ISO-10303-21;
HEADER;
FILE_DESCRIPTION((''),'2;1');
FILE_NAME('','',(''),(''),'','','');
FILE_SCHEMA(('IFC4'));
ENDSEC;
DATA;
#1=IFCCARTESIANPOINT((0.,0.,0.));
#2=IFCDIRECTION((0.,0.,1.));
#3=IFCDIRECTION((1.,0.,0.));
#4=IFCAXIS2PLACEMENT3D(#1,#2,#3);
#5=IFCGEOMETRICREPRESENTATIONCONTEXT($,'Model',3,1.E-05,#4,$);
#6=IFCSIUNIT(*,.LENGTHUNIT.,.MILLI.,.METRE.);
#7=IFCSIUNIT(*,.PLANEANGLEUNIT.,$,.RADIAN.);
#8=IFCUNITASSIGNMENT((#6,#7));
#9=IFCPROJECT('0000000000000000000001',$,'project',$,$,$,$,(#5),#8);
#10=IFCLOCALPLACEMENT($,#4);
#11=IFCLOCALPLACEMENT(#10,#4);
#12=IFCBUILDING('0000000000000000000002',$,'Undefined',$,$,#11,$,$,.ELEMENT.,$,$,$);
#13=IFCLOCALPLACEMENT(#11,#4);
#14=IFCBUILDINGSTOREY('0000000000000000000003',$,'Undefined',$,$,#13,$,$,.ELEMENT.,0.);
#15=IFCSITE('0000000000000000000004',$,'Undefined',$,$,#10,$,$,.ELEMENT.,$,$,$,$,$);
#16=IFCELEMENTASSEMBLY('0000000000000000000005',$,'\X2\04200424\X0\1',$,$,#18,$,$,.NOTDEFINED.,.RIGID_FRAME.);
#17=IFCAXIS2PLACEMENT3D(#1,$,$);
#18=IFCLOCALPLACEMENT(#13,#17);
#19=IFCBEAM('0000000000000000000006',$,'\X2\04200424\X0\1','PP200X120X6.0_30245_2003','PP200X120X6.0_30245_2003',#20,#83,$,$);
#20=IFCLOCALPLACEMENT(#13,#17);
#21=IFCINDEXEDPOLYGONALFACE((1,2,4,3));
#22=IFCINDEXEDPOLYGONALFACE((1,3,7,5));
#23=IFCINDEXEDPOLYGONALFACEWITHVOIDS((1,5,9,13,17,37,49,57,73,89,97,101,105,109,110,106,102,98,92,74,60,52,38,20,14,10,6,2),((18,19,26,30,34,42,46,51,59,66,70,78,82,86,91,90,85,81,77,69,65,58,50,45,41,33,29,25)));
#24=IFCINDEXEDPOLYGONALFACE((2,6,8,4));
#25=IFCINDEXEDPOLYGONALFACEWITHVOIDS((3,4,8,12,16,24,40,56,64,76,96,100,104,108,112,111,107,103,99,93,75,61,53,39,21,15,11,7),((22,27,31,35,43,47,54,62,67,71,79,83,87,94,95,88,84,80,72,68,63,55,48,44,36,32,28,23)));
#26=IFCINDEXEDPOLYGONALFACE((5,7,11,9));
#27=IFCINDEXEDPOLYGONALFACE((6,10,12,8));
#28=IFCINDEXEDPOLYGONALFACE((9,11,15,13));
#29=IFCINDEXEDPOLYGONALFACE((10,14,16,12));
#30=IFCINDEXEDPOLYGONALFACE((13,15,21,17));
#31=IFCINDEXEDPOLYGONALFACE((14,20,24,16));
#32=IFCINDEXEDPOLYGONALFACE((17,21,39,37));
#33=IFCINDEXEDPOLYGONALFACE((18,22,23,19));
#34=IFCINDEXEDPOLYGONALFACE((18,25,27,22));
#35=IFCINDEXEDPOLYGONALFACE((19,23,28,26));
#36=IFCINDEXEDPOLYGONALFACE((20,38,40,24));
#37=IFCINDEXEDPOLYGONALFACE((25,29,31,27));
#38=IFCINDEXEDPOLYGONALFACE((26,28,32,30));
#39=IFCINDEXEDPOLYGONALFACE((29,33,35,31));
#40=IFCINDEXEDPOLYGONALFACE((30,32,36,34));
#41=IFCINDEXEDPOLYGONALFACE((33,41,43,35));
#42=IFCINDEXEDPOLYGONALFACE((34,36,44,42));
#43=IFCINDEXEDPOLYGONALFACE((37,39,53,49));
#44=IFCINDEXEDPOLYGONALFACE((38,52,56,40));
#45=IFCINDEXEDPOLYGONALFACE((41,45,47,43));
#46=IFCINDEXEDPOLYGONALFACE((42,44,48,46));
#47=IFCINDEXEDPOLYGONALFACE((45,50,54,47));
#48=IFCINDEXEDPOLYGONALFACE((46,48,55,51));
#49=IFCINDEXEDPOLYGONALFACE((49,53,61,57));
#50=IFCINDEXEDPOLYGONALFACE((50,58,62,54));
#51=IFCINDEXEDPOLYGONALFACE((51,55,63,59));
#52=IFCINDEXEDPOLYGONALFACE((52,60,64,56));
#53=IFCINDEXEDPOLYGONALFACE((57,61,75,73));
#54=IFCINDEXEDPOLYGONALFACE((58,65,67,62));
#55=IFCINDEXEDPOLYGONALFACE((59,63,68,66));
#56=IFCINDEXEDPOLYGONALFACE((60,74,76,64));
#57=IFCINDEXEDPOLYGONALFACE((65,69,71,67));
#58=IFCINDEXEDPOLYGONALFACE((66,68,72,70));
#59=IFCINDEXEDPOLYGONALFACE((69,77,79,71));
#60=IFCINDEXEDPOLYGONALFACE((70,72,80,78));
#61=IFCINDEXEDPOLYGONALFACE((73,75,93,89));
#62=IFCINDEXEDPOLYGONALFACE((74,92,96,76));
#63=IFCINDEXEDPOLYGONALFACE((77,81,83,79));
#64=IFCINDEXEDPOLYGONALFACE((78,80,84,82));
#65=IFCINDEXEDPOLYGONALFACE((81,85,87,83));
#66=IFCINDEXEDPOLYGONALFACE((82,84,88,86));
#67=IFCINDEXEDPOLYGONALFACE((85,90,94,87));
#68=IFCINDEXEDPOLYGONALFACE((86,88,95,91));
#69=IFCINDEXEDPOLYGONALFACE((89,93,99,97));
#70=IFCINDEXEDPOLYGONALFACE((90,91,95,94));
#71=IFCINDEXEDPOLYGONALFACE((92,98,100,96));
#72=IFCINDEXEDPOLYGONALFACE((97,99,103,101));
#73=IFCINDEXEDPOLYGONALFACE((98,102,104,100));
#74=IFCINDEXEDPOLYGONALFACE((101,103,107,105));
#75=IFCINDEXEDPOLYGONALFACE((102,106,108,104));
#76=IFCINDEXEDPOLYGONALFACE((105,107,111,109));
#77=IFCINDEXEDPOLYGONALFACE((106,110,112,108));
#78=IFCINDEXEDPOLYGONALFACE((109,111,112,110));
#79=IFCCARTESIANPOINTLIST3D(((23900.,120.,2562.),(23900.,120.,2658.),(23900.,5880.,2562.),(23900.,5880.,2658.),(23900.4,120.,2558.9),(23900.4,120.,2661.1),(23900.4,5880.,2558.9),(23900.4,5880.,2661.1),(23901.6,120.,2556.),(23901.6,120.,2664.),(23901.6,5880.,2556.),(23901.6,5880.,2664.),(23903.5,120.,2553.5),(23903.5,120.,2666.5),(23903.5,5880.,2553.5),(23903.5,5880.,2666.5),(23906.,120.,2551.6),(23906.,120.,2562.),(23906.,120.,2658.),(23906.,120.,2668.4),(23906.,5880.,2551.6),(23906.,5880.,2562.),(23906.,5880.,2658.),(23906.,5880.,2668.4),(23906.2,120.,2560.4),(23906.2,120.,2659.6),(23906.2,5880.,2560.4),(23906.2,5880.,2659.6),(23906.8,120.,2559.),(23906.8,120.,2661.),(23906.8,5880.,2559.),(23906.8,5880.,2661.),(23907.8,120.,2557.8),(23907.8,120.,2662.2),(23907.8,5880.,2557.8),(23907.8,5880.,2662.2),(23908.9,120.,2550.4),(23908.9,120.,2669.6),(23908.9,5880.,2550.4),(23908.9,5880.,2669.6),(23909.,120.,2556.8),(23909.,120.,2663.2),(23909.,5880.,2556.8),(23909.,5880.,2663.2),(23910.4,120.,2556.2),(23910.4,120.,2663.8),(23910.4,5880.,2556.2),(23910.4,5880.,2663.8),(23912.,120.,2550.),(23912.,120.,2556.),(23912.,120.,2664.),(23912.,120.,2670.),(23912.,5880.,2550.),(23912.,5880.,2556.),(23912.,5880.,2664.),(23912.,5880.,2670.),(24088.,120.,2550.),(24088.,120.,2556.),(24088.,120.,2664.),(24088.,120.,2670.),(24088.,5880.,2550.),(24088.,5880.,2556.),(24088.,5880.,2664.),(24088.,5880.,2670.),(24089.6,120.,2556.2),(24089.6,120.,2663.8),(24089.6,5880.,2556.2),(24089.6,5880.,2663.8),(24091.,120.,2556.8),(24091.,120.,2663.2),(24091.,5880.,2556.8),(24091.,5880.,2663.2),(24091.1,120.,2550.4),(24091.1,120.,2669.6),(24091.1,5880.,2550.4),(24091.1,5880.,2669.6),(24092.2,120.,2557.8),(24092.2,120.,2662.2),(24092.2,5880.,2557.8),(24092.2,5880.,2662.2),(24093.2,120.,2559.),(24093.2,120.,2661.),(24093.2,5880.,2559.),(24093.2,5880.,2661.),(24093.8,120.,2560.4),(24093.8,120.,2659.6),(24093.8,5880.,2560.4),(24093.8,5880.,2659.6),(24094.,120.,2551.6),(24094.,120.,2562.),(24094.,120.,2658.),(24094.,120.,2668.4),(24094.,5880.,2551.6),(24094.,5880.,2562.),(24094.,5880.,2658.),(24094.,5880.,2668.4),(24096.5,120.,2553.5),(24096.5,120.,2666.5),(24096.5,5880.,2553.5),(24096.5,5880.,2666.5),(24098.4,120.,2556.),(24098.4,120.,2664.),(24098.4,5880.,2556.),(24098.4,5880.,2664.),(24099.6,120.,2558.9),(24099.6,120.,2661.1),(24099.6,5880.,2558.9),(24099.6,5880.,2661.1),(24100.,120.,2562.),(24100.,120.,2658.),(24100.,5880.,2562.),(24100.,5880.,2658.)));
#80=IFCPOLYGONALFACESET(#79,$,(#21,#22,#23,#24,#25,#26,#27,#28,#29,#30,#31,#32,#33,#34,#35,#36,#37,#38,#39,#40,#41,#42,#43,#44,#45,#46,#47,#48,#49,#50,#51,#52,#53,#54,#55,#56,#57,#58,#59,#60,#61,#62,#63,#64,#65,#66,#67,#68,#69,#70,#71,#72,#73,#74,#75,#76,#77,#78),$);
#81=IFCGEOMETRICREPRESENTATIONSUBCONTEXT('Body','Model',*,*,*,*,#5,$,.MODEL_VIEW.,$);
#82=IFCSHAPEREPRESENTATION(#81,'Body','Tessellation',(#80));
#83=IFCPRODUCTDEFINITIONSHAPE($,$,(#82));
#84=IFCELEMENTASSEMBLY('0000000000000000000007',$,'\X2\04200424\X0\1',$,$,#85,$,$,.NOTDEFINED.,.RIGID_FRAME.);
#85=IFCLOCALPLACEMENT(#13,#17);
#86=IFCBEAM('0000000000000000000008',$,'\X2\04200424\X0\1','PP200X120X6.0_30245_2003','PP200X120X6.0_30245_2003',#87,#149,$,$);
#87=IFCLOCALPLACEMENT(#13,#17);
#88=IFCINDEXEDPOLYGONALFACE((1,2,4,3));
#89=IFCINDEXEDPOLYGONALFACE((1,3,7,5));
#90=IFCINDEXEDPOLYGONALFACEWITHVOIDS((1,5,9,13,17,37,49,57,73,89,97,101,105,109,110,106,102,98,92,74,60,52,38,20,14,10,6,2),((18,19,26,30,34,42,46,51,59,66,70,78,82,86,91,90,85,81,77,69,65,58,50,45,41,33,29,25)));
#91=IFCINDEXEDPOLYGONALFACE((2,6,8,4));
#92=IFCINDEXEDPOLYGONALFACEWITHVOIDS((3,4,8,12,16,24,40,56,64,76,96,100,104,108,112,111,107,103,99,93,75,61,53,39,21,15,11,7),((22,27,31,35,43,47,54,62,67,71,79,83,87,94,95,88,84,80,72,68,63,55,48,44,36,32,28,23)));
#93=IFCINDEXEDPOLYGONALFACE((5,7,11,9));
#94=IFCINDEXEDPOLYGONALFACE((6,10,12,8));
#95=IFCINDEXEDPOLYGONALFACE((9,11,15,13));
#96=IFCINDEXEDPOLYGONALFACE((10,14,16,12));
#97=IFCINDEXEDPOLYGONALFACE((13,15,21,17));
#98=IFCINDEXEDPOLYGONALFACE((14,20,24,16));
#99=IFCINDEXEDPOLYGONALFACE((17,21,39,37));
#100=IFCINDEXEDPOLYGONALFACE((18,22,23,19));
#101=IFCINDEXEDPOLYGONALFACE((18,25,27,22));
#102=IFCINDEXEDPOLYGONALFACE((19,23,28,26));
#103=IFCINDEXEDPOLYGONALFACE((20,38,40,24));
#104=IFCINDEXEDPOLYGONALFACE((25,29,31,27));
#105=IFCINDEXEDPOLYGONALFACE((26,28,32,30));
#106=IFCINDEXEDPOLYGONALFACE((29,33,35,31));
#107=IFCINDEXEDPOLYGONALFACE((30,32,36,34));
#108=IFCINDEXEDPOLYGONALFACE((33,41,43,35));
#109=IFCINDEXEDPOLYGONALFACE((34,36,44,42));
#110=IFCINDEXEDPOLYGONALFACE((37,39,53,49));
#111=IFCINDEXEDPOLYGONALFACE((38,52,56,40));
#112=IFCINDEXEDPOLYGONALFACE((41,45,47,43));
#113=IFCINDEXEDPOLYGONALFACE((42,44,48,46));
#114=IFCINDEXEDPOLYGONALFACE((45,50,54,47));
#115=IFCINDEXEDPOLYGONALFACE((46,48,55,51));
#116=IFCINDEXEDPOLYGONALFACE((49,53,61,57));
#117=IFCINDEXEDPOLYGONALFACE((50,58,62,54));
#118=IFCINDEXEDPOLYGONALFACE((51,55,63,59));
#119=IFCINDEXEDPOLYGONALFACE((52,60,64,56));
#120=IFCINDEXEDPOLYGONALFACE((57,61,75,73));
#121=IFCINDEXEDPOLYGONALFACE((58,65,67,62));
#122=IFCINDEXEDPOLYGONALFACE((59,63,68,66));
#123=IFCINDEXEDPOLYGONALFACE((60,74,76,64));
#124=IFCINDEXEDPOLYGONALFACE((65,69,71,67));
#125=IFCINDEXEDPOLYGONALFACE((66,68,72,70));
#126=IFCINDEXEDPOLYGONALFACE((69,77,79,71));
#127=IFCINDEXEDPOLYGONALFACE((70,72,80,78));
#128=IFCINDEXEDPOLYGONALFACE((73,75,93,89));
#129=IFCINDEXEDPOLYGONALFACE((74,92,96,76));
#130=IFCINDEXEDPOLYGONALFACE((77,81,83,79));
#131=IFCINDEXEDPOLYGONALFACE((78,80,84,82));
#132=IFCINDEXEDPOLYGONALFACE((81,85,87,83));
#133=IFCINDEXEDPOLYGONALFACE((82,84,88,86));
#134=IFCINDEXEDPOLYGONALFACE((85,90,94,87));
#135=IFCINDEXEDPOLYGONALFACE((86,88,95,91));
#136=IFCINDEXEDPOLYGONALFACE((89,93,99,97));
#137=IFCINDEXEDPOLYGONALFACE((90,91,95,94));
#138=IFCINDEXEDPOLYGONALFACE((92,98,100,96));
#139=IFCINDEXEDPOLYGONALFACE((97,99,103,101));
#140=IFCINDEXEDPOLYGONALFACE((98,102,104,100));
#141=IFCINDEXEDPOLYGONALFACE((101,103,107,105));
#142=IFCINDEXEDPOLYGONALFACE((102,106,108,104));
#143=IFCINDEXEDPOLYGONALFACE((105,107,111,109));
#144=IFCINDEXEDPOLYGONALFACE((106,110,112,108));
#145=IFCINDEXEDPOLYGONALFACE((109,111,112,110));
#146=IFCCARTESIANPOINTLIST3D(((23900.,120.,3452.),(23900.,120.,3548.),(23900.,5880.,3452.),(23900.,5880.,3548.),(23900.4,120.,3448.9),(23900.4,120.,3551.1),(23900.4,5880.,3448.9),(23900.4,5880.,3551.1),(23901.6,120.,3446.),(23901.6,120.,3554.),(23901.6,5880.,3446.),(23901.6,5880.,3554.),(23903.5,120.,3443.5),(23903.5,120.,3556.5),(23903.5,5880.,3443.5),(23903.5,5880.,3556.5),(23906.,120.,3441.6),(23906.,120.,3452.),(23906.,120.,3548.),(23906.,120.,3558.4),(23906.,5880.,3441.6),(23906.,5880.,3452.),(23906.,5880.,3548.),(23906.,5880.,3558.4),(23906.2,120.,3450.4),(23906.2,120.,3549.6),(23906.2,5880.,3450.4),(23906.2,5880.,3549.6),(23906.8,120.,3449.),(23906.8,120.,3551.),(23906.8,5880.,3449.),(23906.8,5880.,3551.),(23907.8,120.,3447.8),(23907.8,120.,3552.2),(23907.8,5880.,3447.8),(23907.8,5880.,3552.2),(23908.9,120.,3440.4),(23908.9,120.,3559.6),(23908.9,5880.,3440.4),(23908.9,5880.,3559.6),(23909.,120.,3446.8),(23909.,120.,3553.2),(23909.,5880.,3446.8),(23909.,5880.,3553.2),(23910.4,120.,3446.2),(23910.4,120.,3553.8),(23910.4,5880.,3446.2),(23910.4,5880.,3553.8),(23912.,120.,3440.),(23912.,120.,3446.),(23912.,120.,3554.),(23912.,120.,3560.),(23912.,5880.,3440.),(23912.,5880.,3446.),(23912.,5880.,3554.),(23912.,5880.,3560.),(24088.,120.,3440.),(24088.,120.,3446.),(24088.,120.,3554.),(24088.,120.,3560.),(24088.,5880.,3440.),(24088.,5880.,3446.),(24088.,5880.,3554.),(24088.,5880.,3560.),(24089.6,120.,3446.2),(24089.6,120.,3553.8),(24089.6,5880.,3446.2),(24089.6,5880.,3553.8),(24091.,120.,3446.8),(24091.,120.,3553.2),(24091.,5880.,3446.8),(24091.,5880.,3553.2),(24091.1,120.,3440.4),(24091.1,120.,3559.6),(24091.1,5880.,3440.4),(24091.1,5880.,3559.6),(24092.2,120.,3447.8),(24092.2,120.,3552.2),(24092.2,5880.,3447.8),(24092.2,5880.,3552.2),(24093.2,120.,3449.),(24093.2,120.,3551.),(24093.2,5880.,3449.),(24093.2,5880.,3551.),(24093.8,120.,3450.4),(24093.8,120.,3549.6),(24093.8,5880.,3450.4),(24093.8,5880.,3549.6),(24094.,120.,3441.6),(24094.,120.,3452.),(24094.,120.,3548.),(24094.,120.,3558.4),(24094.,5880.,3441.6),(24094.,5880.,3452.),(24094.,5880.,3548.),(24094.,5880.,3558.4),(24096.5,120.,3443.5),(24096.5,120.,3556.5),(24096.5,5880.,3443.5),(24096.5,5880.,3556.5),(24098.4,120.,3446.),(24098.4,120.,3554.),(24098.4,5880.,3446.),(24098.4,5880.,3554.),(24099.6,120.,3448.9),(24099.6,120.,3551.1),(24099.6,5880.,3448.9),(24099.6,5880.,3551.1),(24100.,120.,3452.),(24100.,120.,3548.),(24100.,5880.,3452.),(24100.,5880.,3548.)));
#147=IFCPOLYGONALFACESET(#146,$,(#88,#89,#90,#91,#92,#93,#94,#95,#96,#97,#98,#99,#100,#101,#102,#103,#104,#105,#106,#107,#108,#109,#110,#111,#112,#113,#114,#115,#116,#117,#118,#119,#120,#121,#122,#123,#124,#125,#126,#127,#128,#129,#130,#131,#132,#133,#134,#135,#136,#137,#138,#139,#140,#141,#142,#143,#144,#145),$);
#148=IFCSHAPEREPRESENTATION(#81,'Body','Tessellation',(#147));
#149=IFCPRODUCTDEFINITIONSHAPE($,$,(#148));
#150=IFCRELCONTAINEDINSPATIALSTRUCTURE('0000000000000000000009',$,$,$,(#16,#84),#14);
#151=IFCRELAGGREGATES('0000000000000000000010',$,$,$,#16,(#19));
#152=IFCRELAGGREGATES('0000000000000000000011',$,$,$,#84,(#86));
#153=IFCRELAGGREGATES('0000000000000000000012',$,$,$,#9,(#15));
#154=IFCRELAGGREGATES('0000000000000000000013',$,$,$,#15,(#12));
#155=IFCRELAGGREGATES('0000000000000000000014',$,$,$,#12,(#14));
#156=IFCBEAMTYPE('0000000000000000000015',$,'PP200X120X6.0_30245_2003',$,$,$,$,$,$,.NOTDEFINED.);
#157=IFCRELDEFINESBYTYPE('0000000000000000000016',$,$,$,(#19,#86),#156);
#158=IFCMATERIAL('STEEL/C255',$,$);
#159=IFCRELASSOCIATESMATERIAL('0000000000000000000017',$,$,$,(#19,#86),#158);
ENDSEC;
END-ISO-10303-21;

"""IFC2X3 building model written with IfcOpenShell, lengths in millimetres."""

from ifc_helpers import new_model, si_unit, frame, origin_with_axes, origin_2d_with_axis, place, context, subcontext, project, spatial, hollow_rectangle, extrude, material, type_object, element, aggregate, save


model = new_model("IFC2X3")

# Units and contexts
model_context = context("Model", 3, precision=1e-05, world=origin_with_axes())
body_context = subcontext(model_context, "Body", "Model", "MODEL_VIEW")
ifc_project = project(units=[si_unit("LENGTHUNIT", "METRE", prefix="MILLI"), si_unit("PLANEANGLEUNIT", "RADIAN")], contexts=[model_context])

# Site, building, storey
site_placement = place(None, origin_with_axes())
site = spatial("IfcSite", under=ifc_project, at=site_placement, Name="Undefined", CompositionType="ELEMENT")
building_placement = place(site_placement, origin_with_axes())
building = spatial("IfcBuilding", under=site, at=building_placement, Name="Undefined", CompositionType="ELEMENT")
storey_placement = place(building_placement, origin_with_axes())
storey = spatial("IfcBuildingStorey", under=building, at=storey_placement, Name="Undefined", CompositionType="ELEMENT", Elevation=0.0)

# Element assemblies, beams
assembly_1_placement = place(storey_placement, origin_with_axes())
assembly_1 = element("IfcElementAssembly", 1, at=assembly_1_placement, inside=storey, Name="РФ1", AssemblyPlace="NOTDEFINED", PredefinedType="RIGID_FRAME")
ifc_material_1 = material(Name="STEEL/C255")
beam_type = type_object("IfcBeamType", Name="PP200X120X6.0_30245_2003", PredefinedType="NOTDEFINED")
beam_1_placement = place(assembly_1_placement, frame((24000.0, 120.0, 2610.0), z_axis=(-1.0, 0.0, 0.0), x_axis=(0.0, 1.0, 0.0)))
beam_1 = element("IfcBeam", 2, at=beam_1_placement, type_object=beam_type, material=ifc_material_1, Name="РФ1", Description="PP200X120X6.0_30245_2003", ObjectType="PP200X120X6.0_30245_2003", context=body_context, shape_type="SweptSolid", body=[
    extrude(hollow_rectangle(XDim=120.0, YDim=200.0, WallThickness=6.0, InnerFilletRadius=6.0, OuterFilletRadius=12.0, at=origin_2d_with_axis()), frame((5760.0, 0.0, 0.0), z_axis=(-1.0, 0.0, 0.0), x_axis=(0.0, -1.0, 0.0)), (0.0, 0.0, 1.0), 5760.0),
])
aggregate(assembly_1, [beam_1])
assembly_2_placement = place(storey_placement, origin_with_axes())
assembly_2 = element("IfcElementAssembly", 3, at=assembly_2_placement, inside=storey, Name="РФ1", AssemblyPlace="NOTDEFINED", PredefinedType="RIGID_FRAME")
beam_2_placement = place(assembly_2_placement, frame((24000.0, 120.0, 3500.0), z_axis=(-1.0, 0.0, 0.0), x_axis=(0.0, 1.0, 0.0)))
beam_2 = element("IfcBeam", 4, at=beam_2_placement, type_object=beam_type, material=ifc_material_1, Name="РФ1", Description="PP200X120X6.0_30245_2003", ObjectType="PP200X120X6.0_30245_2003", context=body_context, shape_type="SweptSolid", body=[
    extrude(hollow_rectangle(XDim=120.0, YDim=200.0, WallThickness=6.0, InnerFilletRadius=6.0, OuterFilletRadius=12.0, at=origin_2d_with_axis()), frame((5760.0, 0.0, 0.0), z_axis=(-1.0, 0.0, 0.0), x_axis=(0.0, -1.0, 0.0)), (0.0, 0.0, 1.0), 5760.0),
])
aggregate(assembly_2, [beam_2])

save(model, "model.ifc")
